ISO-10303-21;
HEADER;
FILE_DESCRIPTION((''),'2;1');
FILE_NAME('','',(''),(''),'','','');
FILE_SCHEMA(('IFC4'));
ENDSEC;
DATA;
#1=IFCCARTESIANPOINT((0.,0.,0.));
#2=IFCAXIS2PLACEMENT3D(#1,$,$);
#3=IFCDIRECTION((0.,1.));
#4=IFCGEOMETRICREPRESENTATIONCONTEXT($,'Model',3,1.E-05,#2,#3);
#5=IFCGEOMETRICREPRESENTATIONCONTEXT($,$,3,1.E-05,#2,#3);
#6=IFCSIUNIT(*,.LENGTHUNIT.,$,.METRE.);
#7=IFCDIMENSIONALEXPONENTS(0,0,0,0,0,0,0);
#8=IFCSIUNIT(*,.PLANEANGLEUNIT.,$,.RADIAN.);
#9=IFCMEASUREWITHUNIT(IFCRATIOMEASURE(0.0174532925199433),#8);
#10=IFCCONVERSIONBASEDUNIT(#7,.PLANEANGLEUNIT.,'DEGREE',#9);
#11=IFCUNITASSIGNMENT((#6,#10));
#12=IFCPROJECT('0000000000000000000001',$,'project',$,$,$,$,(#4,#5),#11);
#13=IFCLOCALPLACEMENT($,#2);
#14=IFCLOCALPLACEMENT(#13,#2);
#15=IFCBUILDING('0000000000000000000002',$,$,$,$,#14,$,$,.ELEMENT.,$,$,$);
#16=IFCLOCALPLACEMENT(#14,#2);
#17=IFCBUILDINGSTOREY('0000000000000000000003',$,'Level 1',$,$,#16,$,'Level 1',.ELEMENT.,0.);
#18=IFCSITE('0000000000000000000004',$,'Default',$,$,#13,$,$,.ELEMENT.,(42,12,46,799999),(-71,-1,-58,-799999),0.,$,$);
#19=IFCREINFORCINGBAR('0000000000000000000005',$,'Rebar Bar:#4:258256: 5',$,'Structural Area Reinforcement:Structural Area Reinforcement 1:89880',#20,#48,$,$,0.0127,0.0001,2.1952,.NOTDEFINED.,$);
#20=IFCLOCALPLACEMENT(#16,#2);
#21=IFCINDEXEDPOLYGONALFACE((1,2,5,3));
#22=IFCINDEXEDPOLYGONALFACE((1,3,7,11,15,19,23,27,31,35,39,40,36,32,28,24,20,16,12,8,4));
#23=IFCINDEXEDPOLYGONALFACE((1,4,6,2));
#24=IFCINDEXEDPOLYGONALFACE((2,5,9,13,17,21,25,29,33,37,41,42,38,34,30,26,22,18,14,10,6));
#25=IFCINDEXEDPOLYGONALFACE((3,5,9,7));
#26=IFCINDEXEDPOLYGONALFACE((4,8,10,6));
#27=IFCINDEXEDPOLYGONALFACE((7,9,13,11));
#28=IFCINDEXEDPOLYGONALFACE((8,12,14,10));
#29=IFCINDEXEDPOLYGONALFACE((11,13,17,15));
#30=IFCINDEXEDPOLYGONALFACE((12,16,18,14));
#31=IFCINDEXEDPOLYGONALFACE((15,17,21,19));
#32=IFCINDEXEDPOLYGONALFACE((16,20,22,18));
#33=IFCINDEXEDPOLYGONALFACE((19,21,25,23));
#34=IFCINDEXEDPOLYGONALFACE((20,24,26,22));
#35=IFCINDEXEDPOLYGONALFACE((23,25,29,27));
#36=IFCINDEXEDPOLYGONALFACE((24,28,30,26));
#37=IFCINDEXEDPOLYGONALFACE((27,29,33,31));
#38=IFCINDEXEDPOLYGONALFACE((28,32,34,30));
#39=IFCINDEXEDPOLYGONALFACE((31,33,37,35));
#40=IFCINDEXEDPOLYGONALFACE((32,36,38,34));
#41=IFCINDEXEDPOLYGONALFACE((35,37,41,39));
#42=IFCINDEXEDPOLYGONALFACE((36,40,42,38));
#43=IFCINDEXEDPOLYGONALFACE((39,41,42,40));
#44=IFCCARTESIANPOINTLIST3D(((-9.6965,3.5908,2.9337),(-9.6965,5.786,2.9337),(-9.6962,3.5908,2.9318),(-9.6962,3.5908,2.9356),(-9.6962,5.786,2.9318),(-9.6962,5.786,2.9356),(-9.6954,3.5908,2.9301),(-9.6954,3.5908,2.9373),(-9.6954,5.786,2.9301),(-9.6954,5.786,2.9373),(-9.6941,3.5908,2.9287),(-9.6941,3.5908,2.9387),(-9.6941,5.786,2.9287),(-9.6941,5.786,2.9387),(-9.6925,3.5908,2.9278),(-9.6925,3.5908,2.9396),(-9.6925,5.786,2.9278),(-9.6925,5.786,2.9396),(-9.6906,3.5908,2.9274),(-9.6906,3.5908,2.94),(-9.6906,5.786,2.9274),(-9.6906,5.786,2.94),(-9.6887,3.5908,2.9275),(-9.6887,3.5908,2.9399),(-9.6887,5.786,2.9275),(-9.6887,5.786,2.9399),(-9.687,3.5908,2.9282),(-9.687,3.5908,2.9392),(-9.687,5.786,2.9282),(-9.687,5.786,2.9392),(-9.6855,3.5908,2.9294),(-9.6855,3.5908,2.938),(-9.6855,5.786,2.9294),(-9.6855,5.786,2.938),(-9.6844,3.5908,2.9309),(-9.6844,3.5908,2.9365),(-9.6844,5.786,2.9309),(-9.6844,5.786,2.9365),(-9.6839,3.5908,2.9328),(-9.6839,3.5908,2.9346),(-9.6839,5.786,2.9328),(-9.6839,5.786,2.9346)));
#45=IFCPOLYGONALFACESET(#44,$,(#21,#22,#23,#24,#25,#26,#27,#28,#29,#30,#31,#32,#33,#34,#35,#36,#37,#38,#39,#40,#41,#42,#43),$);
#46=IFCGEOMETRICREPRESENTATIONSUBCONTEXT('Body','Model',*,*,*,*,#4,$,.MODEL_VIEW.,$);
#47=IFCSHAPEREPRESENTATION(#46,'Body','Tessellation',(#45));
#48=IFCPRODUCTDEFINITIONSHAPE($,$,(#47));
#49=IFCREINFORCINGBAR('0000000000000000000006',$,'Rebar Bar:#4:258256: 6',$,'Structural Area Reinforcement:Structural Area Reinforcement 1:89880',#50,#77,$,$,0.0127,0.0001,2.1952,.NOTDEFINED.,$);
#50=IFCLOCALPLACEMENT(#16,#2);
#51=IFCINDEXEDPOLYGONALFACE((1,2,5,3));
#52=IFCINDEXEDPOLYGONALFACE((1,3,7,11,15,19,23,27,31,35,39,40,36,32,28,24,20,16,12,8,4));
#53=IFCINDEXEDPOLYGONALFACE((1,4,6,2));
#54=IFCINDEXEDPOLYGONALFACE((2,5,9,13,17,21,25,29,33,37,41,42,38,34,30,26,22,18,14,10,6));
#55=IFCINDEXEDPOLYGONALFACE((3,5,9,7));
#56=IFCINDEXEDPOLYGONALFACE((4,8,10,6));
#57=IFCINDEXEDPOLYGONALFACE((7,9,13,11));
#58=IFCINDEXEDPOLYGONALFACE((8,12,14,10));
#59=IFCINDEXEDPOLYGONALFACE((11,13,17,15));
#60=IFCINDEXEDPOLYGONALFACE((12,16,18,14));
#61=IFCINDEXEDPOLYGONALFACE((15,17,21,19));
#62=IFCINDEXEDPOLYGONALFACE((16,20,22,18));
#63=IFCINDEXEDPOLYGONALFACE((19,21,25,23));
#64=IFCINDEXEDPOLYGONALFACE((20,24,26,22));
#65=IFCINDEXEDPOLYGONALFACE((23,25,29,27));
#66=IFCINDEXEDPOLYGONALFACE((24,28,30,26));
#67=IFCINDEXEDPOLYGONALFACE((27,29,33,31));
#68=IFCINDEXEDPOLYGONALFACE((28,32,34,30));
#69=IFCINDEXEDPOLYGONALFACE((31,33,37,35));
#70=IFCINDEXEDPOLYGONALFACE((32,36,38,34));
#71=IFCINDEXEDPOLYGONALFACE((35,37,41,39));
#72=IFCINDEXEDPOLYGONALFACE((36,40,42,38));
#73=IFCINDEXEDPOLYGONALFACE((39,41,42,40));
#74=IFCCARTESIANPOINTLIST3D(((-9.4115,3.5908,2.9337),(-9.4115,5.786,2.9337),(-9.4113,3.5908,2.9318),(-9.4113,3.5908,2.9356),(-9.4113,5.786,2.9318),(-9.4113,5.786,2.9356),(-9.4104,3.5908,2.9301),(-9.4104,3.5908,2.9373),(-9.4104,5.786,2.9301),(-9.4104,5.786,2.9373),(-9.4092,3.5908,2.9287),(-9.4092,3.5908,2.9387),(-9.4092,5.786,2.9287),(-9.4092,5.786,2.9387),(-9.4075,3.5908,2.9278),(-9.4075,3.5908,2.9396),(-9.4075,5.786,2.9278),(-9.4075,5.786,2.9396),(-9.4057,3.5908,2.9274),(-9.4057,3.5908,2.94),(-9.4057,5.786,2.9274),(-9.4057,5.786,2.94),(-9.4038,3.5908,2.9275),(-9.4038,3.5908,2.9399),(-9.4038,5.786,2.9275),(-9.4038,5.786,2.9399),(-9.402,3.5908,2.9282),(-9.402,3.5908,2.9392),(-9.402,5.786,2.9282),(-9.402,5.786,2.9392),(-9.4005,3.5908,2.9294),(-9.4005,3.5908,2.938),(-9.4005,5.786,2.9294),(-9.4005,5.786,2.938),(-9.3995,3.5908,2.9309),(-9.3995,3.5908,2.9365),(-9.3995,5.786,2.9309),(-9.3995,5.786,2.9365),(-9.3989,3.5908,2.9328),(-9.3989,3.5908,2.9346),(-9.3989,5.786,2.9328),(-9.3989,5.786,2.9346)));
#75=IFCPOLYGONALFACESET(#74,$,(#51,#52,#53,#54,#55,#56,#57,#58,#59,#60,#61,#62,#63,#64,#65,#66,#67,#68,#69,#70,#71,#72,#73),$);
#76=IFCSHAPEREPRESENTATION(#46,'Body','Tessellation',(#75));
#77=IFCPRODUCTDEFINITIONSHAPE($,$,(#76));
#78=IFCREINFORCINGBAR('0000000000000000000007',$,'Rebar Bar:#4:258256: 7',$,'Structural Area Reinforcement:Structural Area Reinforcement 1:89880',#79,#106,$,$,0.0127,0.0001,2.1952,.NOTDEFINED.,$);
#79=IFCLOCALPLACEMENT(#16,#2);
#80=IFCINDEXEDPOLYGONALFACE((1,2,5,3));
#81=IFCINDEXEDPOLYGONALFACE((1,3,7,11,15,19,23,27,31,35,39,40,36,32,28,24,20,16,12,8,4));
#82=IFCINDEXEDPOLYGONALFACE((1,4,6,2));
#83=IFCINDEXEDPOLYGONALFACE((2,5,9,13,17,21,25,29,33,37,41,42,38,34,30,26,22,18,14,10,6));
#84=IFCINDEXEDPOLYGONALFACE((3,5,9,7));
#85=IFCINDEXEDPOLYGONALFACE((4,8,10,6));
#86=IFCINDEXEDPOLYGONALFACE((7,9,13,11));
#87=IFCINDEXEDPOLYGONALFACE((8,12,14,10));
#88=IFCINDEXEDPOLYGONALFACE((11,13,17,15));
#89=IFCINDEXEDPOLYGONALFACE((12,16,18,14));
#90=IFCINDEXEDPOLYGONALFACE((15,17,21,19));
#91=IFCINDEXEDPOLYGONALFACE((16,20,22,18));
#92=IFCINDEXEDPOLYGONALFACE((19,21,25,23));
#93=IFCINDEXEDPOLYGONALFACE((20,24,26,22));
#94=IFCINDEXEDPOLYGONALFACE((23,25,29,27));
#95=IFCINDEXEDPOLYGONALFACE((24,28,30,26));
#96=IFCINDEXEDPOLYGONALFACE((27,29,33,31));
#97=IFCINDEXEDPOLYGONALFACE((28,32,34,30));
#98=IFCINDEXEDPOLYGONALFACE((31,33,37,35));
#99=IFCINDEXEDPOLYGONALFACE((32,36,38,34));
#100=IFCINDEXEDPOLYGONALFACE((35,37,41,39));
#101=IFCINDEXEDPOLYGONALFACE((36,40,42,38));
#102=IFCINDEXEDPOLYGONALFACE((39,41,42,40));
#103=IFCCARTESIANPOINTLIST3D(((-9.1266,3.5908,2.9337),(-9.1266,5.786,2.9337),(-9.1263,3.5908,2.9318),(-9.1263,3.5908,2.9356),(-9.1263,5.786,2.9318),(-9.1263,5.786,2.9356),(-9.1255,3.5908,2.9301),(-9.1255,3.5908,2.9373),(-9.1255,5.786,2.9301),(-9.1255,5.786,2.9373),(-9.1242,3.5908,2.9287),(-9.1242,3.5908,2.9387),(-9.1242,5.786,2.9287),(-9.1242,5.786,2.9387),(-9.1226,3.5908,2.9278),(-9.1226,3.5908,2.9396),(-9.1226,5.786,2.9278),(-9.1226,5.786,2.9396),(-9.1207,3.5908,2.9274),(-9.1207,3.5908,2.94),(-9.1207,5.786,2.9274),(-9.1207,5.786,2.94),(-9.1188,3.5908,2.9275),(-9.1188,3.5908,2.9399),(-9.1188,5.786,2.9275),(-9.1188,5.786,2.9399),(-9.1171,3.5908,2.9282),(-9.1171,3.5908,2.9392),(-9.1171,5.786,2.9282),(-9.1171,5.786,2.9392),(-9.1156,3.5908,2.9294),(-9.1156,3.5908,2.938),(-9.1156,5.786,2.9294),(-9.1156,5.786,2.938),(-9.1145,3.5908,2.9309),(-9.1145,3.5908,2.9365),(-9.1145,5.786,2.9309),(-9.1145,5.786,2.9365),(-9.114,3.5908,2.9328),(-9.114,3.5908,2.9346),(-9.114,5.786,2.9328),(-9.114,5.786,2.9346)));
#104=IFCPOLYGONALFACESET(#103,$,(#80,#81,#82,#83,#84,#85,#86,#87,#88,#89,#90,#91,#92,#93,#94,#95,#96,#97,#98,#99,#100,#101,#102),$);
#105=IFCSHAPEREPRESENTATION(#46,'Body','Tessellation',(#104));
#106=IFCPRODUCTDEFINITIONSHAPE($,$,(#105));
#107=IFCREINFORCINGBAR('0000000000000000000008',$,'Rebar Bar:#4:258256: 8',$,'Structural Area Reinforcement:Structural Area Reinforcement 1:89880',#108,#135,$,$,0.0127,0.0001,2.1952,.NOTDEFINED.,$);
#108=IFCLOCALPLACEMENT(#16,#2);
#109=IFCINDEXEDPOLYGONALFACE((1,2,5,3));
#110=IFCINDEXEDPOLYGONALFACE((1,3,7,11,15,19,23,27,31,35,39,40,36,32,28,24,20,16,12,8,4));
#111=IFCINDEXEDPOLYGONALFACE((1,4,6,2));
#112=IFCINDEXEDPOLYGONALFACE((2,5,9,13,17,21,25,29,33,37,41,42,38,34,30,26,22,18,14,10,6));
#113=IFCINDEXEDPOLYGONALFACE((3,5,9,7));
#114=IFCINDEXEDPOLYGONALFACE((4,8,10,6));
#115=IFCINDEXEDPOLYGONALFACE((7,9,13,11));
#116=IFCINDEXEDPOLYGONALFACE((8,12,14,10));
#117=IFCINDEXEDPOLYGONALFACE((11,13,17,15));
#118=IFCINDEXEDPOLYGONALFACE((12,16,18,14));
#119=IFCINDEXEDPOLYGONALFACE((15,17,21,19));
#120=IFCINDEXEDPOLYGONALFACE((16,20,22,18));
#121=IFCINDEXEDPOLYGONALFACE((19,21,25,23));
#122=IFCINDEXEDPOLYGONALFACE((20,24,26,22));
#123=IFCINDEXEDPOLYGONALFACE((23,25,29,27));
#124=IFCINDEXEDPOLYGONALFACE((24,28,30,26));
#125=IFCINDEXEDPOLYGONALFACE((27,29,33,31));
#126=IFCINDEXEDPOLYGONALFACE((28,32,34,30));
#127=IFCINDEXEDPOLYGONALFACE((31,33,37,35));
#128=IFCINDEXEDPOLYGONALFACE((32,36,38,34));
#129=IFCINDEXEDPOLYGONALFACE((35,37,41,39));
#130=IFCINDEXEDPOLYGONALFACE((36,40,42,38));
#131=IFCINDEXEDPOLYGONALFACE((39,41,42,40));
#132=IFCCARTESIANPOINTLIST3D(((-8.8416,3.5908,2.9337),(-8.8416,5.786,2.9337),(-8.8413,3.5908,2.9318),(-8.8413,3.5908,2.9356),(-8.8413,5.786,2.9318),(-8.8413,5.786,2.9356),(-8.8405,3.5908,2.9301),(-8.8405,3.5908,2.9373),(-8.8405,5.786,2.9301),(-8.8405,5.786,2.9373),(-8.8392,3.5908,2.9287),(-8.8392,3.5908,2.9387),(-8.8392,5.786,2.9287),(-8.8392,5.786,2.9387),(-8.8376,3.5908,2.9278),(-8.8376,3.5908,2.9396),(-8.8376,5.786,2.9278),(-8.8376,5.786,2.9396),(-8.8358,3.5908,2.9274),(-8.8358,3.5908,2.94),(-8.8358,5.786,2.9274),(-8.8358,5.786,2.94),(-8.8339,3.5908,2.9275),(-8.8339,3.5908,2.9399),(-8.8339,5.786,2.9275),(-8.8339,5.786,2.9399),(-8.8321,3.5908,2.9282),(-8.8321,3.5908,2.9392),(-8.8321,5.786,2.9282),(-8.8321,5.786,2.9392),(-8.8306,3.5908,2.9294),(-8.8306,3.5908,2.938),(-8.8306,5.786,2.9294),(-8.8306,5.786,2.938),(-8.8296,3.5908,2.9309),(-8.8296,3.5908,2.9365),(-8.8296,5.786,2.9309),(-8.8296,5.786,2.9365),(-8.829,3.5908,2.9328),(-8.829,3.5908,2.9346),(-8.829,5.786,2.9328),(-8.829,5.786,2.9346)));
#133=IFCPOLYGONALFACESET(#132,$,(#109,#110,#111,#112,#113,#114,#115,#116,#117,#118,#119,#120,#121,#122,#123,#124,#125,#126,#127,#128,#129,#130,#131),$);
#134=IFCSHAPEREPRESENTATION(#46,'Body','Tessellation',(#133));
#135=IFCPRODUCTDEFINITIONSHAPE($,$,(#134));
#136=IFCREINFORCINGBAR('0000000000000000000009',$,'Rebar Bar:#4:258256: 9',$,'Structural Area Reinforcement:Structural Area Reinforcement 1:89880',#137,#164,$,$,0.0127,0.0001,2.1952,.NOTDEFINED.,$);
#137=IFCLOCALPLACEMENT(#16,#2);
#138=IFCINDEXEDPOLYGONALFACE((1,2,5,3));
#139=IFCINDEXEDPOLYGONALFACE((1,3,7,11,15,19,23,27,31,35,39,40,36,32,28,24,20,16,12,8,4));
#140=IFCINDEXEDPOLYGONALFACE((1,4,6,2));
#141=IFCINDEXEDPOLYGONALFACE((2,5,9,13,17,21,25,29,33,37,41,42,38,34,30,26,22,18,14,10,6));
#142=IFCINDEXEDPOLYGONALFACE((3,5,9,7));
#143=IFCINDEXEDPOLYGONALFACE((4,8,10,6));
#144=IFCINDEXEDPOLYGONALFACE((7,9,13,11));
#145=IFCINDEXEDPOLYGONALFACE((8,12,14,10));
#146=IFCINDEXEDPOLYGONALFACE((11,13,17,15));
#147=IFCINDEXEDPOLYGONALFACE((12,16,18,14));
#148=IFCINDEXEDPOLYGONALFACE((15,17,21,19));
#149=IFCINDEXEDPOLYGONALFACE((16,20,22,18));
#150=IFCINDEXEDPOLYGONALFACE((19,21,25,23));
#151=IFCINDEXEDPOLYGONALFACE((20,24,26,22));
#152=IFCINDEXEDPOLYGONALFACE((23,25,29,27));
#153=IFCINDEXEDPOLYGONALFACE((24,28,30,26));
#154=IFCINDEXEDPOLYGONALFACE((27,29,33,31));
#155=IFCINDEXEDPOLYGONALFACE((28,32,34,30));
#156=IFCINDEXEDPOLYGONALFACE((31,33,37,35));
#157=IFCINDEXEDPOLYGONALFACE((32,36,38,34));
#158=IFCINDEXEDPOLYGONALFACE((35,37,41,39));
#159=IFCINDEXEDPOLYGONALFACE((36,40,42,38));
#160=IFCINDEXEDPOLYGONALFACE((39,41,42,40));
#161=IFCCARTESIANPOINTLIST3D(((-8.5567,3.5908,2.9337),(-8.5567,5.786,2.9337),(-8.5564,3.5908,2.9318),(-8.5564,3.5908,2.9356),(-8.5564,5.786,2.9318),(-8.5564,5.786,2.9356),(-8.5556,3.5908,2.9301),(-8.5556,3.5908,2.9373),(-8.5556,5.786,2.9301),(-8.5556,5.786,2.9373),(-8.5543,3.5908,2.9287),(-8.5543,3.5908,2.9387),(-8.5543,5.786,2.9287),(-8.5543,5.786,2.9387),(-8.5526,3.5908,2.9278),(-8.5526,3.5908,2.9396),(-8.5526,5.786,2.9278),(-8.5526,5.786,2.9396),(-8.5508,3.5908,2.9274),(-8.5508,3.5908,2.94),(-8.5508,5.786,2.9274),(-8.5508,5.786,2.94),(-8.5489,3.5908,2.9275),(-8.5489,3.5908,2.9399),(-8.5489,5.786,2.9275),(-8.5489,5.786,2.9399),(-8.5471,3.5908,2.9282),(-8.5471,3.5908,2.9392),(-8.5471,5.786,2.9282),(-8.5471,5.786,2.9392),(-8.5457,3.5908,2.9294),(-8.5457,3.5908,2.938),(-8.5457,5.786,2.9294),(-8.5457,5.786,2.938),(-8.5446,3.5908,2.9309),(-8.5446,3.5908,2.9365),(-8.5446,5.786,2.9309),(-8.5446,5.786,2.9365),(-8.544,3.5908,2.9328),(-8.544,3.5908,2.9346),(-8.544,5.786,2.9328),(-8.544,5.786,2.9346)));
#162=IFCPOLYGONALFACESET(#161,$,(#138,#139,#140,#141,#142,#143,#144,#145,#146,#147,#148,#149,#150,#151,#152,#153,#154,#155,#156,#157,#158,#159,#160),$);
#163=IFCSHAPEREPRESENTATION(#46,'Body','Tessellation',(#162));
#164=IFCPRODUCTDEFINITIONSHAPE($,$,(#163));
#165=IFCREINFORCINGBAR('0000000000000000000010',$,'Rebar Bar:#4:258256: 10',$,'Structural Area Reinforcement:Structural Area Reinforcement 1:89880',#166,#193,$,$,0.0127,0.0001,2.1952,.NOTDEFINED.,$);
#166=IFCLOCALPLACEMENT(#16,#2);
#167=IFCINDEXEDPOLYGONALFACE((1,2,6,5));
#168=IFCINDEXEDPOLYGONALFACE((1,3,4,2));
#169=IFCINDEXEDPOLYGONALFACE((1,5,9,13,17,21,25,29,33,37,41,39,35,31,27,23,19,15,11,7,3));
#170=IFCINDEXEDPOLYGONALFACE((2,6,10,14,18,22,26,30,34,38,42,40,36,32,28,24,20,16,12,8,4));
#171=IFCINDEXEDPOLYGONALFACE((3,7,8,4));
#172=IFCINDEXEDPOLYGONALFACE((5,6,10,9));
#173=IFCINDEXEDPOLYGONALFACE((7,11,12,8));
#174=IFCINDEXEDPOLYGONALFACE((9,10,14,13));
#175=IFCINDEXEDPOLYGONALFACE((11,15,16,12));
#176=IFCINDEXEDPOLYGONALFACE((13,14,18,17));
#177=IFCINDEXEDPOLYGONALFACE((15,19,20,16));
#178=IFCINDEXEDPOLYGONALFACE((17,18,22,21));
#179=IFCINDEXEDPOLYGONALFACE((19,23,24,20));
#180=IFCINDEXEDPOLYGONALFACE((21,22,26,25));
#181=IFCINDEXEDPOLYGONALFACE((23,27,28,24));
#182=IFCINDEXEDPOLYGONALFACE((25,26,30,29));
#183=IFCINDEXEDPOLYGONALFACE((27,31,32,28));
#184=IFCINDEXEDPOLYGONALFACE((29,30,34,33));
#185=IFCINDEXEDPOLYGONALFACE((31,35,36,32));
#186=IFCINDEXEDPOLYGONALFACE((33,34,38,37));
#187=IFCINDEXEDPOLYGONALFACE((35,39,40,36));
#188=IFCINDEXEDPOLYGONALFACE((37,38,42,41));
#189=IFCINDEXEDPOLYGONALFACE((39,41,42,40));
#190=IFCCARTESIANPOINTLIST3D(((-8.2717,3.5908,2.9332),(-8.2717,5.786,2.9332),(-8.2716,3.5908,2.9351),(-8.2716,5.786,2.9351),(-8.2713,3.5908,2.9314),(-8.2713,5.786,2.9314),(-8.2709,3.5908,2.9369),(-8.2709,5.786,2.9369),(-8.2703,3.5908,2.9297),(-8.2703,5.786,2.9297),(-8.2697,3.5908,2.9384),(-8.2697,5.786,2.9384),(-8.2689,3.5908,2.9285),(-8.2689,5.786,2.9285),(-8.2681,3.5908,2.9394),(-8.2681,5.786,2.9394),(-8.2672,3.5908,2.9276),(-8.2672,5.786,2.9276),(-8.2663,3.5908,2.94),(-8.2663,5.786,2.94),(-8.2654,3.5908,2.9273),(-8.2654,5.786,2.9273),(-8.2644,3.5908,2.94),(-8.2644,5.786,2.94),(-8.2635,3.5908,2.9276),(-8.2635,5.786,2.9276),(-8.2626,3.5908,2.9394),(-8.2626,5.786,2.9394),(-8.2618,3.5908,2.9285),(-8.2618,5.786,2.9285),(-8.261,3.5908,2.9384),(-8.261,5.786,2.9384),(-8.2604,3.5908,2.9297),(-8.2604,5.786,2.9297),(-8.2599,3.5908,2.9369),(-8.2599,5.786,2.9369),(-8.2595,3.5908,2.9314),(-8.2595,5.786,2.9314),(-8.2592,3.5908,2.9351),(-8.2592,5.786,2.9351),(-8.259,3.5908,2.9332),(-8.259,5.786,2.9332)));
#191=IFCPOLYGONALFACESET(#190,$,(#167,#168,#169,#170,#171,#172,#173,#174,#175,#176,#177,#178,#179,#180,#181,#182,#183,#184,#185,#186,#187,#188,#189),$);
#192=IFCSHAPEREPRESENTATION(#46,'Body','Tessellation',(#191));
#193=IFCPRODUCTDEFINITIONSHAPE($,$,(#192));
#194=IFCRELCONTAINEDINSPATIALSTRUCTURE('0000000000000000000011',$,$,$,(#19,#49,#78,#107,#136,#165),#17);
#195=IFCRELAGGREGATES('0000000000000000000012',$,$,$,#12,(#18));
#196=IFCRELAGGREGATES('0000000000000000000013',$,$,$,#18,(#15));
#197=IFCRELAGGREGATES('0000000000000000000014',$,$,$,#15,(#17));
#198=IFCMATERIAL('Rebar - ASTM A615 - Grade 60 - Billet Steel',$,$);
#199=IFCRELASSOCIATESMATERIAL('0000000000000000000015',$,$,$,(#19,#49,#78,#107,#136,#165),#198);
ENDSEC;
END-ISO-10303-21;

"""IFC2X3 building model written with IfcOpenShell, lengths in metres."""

from ifc_helpers import new_model, entity, si_unit, converted_unit, direction, origin, place, context, subcontext, project, spatial, material, element, save


model = new_model("IFC2X3")

# Units and contexts
model_context = context("Model", 3, precision=1e-05, world=origin(), true_north=direction((0.0, 1.0)))
context_of_model = context(None, 3, precision=1e-05, world=origin(), true_north=direction((0.0, 1.0)))
body_context = subcontext(model_context, "Body", "Model", "MODEL_VIEW")
ifc_project = project(units=[si_unit("LENGTHUNIT", "METRE"), converted_unit("PLANEANGLEUNIT", "DEGREE", entity("IfcRatioMeasure", 0.0174532925199433), si_unit("PLANEANGLEUNIT", "RADIAN"), dimensions=[0, 0, 0, 0, 0, 0, 0])], contexts=[model_context, context_of_model])

# Site, building, storey
site_placement = place(None, origin())
site = spatial("IfcSite", under=ifc_project, at=site_placement, Name="Default", CompositionType="ELEMENT", RefLatitude=(42, 12, 46, 799999), RefLongitude=(-71, -1, -58, -799999), RefElevation=0.0)
building_placement = place(site_placement, origin())
building = spatial("IfcBuilding", under=site, at=building_placement, CompositionType="ELEMENT")
storey_placement = place(building_placement, origin())
storey = spatial("IfcBuildingStorey", under=building, at=storey_placement, Name="Level 1", LongName="Level 1", CompositionType="ELEMENT", Elevation=0.0)

# Reinforcing bars
ifc_material_1 = material(Name="Rebar - ASTM A615 - Grade 60 - Billet Steel")
reinforcing_bar_1_placement = place(storey_placement, origin())
element("IfcReinforcingBar", 1, at=reinforcing_bar_1_placement, inside=storey, material=ifc_material_1, Name="Rebar Bar:#4:258256: 5", ObjectType="Structural Area Reinforcement:Structural Area Reinforcement 1:89880", BarLength=2.1952, BarRole="NOTDEFINED", CrossSectionArea=0.0001, NominalDiameter=0.0127, context=body_context, shape_type="AdvancedSweptSolid", body=[
    entity("IfcSweptDiskSolid", entity("IfcCompositeCurve", [entity("IfcCompositeCurveSegment", "CONTINUOUS", True, entity("IfcPolyline", [entity("IfcCartesianPoint", [-9.6901, 5.786, 2.9337]), entity("IfcCartesianPoint", [-9.6901, 3.5908, 2.9337])]))], False), 0.0063, None, 0.0, 1.0),
])
reinforcing_bar_2_placement = place(storey_placement, origin())
element("IfcReinforcingBar", 2, at=reinforcing_bar_2_placement, inside=storey, material=ifc_material_1, Name="Rebar Bar:#4:258256: 6", ObjectType="Structural Area Reinforcement:Structural Area Reinforcement 1:89880", BarLength=2.1952, BarRole="NOTDEFINED", CrossSectionArea=0.0001, NominalDiameter=0.0127, context=body_context, shape_type="AdvancedSweptSolid", body=[
    entity("IfcSweptDiskSolid", entity("IfcCompositeCurve", [entity("IfcCompositeCurveSegment", "CONTINUOUS", True, entity("IfcPolyline", [entity("IfcCartesianPoint", [-9.4052, 5.786, 2.9337]), entity("IfcCartesianPoint", [-9.4052, 3.5908, 2.9337])]))], False), 0.0063, None, 0.0, 1.0),
])
reinforcing_bar_3_placement = place(storey_placement, origin())
element("IfcReinforcingBar", 3, at=reinforcing_bar_3_placement, inside=storey, material=ifc_material_1, Name="Rebar Bar:#4:258256: 7", ObjectType="Structural Area Reinforcement:Structural Area Reinforcement 1:89880", BarLength=2.1952, BarRole="NOTDEFINED", CrossSectionArea=0.0001, NominalDiameter=0.0127, context=body_context, shape_type="AdvancedSweptSolid", body=[
    entity("IfcSweptDiskSolid", entity("IfcCompositeCurve", [entity("IfcCompositeCurveSegment", "CONTINUOUS", True, entity("IfcPolyline", [entity("IfcCartesianPoint", [-9.1202, 5.786, 2.9337]), entity("IfcCartesianPoint", [-9.1202, 3.5908, 2.9337])]))], False), 0.0063, None, 0.0, 1.0),
])
reinforcing_bar_4_placement = place(storey_placement, origin())
element("IfcReinforcingBar", 4, at=reinforcing_bar_4_placement, inside=storey, material=ifc_material_1, Name="Rebar Bar:#4:258256: 8", ObjectType="Structural Area Reinforcement:Structural Area Reinforcement 1:89880", BarLength=2.1952, BarRole="NOTDEFINED", CrossSectionArea=0.0001, NominalDiameter=0.0127, context=body_context, shape_type="AdvancedSweptSolid", body=[
    entity("IfcSweptDiskSolid", entity("IfcCompositeCurve", [entity("IfcCompositeCurveSegment", "CONTINUOUS", True, entity("IfcPolyline", [entity("IfcCartesianPoint", [-8.8353, 5.786, 2.9337]), entity("IfcCartesianPoint", [-8.8353, 3.5908, 2.9337])]))], False), 0.0063, None, 0.0, 1.0),
])
reinforcing_bar_5_placement = place(storey_placement, origin())
element("IfcReinforcingBar", 5, at=reinforcing_bar_5_placement, inside=storey, material=ifc_material_1, Name="Rebar Bar:#4:258256: 9", ObjectType="Structural Area Reinforcement:Structural Area Reinforcement 1:89880", BarLength=2.1952, BarRole="NOTDEFINED", CrossSectionArea=0.0001, NominalDiameter=0.0127, context=body_context, shape_type="AdvancedSweptSolid", body=[
    entity("IfcSweptDiskSolid", entity("IfcCompositeCurve", [entity("IfcCompositeCurveSegment", "CONTINUOUS", True, entity("IfcPolyline", [entity("IfcCartesianPoint", [-8.5503, 5.786, 2.9337]), entity("IfcCartesianPoint", [-8.5503, 3.5908, 2.9337])]))], False), 0.0063, None, 0.0, 1.0),
])
reinforcing_bar_6_placement = place(storey_placement, origin())
element("IfcReinforcingBar", 6, at=reinforcing_bar_6_placement, inside=storey, material=ifc_material_1, Name="Rebar Bar:#4:258256: 10", ObjectType="Structural Area Reinforcement:Structural Area Reinforcement 1:89880", BarLength=2.1952, BarRole="NOTDEFINED", CrossSectionArea=0.0001, NominalDiameter=0.0127, context=body_context, shape_type="AdvancedSweptSolid", body=[
    entity("IfcSweptDiskSolid", entity("IfcCompositeCurve", [entity("IfcCompositeCurveSegment", "CONTINUOUS", True, entity("IfcPolyline", [entity("IfcCartesianPoint", [-8.2654, 5.786, 2.9337]), entity("IfcCartesianPoint", [-8.2654, 3.5908, 2.9337])]))], False), 0.0063, None, 0.0, 1.0),
])

save(model, "model.ifc")
